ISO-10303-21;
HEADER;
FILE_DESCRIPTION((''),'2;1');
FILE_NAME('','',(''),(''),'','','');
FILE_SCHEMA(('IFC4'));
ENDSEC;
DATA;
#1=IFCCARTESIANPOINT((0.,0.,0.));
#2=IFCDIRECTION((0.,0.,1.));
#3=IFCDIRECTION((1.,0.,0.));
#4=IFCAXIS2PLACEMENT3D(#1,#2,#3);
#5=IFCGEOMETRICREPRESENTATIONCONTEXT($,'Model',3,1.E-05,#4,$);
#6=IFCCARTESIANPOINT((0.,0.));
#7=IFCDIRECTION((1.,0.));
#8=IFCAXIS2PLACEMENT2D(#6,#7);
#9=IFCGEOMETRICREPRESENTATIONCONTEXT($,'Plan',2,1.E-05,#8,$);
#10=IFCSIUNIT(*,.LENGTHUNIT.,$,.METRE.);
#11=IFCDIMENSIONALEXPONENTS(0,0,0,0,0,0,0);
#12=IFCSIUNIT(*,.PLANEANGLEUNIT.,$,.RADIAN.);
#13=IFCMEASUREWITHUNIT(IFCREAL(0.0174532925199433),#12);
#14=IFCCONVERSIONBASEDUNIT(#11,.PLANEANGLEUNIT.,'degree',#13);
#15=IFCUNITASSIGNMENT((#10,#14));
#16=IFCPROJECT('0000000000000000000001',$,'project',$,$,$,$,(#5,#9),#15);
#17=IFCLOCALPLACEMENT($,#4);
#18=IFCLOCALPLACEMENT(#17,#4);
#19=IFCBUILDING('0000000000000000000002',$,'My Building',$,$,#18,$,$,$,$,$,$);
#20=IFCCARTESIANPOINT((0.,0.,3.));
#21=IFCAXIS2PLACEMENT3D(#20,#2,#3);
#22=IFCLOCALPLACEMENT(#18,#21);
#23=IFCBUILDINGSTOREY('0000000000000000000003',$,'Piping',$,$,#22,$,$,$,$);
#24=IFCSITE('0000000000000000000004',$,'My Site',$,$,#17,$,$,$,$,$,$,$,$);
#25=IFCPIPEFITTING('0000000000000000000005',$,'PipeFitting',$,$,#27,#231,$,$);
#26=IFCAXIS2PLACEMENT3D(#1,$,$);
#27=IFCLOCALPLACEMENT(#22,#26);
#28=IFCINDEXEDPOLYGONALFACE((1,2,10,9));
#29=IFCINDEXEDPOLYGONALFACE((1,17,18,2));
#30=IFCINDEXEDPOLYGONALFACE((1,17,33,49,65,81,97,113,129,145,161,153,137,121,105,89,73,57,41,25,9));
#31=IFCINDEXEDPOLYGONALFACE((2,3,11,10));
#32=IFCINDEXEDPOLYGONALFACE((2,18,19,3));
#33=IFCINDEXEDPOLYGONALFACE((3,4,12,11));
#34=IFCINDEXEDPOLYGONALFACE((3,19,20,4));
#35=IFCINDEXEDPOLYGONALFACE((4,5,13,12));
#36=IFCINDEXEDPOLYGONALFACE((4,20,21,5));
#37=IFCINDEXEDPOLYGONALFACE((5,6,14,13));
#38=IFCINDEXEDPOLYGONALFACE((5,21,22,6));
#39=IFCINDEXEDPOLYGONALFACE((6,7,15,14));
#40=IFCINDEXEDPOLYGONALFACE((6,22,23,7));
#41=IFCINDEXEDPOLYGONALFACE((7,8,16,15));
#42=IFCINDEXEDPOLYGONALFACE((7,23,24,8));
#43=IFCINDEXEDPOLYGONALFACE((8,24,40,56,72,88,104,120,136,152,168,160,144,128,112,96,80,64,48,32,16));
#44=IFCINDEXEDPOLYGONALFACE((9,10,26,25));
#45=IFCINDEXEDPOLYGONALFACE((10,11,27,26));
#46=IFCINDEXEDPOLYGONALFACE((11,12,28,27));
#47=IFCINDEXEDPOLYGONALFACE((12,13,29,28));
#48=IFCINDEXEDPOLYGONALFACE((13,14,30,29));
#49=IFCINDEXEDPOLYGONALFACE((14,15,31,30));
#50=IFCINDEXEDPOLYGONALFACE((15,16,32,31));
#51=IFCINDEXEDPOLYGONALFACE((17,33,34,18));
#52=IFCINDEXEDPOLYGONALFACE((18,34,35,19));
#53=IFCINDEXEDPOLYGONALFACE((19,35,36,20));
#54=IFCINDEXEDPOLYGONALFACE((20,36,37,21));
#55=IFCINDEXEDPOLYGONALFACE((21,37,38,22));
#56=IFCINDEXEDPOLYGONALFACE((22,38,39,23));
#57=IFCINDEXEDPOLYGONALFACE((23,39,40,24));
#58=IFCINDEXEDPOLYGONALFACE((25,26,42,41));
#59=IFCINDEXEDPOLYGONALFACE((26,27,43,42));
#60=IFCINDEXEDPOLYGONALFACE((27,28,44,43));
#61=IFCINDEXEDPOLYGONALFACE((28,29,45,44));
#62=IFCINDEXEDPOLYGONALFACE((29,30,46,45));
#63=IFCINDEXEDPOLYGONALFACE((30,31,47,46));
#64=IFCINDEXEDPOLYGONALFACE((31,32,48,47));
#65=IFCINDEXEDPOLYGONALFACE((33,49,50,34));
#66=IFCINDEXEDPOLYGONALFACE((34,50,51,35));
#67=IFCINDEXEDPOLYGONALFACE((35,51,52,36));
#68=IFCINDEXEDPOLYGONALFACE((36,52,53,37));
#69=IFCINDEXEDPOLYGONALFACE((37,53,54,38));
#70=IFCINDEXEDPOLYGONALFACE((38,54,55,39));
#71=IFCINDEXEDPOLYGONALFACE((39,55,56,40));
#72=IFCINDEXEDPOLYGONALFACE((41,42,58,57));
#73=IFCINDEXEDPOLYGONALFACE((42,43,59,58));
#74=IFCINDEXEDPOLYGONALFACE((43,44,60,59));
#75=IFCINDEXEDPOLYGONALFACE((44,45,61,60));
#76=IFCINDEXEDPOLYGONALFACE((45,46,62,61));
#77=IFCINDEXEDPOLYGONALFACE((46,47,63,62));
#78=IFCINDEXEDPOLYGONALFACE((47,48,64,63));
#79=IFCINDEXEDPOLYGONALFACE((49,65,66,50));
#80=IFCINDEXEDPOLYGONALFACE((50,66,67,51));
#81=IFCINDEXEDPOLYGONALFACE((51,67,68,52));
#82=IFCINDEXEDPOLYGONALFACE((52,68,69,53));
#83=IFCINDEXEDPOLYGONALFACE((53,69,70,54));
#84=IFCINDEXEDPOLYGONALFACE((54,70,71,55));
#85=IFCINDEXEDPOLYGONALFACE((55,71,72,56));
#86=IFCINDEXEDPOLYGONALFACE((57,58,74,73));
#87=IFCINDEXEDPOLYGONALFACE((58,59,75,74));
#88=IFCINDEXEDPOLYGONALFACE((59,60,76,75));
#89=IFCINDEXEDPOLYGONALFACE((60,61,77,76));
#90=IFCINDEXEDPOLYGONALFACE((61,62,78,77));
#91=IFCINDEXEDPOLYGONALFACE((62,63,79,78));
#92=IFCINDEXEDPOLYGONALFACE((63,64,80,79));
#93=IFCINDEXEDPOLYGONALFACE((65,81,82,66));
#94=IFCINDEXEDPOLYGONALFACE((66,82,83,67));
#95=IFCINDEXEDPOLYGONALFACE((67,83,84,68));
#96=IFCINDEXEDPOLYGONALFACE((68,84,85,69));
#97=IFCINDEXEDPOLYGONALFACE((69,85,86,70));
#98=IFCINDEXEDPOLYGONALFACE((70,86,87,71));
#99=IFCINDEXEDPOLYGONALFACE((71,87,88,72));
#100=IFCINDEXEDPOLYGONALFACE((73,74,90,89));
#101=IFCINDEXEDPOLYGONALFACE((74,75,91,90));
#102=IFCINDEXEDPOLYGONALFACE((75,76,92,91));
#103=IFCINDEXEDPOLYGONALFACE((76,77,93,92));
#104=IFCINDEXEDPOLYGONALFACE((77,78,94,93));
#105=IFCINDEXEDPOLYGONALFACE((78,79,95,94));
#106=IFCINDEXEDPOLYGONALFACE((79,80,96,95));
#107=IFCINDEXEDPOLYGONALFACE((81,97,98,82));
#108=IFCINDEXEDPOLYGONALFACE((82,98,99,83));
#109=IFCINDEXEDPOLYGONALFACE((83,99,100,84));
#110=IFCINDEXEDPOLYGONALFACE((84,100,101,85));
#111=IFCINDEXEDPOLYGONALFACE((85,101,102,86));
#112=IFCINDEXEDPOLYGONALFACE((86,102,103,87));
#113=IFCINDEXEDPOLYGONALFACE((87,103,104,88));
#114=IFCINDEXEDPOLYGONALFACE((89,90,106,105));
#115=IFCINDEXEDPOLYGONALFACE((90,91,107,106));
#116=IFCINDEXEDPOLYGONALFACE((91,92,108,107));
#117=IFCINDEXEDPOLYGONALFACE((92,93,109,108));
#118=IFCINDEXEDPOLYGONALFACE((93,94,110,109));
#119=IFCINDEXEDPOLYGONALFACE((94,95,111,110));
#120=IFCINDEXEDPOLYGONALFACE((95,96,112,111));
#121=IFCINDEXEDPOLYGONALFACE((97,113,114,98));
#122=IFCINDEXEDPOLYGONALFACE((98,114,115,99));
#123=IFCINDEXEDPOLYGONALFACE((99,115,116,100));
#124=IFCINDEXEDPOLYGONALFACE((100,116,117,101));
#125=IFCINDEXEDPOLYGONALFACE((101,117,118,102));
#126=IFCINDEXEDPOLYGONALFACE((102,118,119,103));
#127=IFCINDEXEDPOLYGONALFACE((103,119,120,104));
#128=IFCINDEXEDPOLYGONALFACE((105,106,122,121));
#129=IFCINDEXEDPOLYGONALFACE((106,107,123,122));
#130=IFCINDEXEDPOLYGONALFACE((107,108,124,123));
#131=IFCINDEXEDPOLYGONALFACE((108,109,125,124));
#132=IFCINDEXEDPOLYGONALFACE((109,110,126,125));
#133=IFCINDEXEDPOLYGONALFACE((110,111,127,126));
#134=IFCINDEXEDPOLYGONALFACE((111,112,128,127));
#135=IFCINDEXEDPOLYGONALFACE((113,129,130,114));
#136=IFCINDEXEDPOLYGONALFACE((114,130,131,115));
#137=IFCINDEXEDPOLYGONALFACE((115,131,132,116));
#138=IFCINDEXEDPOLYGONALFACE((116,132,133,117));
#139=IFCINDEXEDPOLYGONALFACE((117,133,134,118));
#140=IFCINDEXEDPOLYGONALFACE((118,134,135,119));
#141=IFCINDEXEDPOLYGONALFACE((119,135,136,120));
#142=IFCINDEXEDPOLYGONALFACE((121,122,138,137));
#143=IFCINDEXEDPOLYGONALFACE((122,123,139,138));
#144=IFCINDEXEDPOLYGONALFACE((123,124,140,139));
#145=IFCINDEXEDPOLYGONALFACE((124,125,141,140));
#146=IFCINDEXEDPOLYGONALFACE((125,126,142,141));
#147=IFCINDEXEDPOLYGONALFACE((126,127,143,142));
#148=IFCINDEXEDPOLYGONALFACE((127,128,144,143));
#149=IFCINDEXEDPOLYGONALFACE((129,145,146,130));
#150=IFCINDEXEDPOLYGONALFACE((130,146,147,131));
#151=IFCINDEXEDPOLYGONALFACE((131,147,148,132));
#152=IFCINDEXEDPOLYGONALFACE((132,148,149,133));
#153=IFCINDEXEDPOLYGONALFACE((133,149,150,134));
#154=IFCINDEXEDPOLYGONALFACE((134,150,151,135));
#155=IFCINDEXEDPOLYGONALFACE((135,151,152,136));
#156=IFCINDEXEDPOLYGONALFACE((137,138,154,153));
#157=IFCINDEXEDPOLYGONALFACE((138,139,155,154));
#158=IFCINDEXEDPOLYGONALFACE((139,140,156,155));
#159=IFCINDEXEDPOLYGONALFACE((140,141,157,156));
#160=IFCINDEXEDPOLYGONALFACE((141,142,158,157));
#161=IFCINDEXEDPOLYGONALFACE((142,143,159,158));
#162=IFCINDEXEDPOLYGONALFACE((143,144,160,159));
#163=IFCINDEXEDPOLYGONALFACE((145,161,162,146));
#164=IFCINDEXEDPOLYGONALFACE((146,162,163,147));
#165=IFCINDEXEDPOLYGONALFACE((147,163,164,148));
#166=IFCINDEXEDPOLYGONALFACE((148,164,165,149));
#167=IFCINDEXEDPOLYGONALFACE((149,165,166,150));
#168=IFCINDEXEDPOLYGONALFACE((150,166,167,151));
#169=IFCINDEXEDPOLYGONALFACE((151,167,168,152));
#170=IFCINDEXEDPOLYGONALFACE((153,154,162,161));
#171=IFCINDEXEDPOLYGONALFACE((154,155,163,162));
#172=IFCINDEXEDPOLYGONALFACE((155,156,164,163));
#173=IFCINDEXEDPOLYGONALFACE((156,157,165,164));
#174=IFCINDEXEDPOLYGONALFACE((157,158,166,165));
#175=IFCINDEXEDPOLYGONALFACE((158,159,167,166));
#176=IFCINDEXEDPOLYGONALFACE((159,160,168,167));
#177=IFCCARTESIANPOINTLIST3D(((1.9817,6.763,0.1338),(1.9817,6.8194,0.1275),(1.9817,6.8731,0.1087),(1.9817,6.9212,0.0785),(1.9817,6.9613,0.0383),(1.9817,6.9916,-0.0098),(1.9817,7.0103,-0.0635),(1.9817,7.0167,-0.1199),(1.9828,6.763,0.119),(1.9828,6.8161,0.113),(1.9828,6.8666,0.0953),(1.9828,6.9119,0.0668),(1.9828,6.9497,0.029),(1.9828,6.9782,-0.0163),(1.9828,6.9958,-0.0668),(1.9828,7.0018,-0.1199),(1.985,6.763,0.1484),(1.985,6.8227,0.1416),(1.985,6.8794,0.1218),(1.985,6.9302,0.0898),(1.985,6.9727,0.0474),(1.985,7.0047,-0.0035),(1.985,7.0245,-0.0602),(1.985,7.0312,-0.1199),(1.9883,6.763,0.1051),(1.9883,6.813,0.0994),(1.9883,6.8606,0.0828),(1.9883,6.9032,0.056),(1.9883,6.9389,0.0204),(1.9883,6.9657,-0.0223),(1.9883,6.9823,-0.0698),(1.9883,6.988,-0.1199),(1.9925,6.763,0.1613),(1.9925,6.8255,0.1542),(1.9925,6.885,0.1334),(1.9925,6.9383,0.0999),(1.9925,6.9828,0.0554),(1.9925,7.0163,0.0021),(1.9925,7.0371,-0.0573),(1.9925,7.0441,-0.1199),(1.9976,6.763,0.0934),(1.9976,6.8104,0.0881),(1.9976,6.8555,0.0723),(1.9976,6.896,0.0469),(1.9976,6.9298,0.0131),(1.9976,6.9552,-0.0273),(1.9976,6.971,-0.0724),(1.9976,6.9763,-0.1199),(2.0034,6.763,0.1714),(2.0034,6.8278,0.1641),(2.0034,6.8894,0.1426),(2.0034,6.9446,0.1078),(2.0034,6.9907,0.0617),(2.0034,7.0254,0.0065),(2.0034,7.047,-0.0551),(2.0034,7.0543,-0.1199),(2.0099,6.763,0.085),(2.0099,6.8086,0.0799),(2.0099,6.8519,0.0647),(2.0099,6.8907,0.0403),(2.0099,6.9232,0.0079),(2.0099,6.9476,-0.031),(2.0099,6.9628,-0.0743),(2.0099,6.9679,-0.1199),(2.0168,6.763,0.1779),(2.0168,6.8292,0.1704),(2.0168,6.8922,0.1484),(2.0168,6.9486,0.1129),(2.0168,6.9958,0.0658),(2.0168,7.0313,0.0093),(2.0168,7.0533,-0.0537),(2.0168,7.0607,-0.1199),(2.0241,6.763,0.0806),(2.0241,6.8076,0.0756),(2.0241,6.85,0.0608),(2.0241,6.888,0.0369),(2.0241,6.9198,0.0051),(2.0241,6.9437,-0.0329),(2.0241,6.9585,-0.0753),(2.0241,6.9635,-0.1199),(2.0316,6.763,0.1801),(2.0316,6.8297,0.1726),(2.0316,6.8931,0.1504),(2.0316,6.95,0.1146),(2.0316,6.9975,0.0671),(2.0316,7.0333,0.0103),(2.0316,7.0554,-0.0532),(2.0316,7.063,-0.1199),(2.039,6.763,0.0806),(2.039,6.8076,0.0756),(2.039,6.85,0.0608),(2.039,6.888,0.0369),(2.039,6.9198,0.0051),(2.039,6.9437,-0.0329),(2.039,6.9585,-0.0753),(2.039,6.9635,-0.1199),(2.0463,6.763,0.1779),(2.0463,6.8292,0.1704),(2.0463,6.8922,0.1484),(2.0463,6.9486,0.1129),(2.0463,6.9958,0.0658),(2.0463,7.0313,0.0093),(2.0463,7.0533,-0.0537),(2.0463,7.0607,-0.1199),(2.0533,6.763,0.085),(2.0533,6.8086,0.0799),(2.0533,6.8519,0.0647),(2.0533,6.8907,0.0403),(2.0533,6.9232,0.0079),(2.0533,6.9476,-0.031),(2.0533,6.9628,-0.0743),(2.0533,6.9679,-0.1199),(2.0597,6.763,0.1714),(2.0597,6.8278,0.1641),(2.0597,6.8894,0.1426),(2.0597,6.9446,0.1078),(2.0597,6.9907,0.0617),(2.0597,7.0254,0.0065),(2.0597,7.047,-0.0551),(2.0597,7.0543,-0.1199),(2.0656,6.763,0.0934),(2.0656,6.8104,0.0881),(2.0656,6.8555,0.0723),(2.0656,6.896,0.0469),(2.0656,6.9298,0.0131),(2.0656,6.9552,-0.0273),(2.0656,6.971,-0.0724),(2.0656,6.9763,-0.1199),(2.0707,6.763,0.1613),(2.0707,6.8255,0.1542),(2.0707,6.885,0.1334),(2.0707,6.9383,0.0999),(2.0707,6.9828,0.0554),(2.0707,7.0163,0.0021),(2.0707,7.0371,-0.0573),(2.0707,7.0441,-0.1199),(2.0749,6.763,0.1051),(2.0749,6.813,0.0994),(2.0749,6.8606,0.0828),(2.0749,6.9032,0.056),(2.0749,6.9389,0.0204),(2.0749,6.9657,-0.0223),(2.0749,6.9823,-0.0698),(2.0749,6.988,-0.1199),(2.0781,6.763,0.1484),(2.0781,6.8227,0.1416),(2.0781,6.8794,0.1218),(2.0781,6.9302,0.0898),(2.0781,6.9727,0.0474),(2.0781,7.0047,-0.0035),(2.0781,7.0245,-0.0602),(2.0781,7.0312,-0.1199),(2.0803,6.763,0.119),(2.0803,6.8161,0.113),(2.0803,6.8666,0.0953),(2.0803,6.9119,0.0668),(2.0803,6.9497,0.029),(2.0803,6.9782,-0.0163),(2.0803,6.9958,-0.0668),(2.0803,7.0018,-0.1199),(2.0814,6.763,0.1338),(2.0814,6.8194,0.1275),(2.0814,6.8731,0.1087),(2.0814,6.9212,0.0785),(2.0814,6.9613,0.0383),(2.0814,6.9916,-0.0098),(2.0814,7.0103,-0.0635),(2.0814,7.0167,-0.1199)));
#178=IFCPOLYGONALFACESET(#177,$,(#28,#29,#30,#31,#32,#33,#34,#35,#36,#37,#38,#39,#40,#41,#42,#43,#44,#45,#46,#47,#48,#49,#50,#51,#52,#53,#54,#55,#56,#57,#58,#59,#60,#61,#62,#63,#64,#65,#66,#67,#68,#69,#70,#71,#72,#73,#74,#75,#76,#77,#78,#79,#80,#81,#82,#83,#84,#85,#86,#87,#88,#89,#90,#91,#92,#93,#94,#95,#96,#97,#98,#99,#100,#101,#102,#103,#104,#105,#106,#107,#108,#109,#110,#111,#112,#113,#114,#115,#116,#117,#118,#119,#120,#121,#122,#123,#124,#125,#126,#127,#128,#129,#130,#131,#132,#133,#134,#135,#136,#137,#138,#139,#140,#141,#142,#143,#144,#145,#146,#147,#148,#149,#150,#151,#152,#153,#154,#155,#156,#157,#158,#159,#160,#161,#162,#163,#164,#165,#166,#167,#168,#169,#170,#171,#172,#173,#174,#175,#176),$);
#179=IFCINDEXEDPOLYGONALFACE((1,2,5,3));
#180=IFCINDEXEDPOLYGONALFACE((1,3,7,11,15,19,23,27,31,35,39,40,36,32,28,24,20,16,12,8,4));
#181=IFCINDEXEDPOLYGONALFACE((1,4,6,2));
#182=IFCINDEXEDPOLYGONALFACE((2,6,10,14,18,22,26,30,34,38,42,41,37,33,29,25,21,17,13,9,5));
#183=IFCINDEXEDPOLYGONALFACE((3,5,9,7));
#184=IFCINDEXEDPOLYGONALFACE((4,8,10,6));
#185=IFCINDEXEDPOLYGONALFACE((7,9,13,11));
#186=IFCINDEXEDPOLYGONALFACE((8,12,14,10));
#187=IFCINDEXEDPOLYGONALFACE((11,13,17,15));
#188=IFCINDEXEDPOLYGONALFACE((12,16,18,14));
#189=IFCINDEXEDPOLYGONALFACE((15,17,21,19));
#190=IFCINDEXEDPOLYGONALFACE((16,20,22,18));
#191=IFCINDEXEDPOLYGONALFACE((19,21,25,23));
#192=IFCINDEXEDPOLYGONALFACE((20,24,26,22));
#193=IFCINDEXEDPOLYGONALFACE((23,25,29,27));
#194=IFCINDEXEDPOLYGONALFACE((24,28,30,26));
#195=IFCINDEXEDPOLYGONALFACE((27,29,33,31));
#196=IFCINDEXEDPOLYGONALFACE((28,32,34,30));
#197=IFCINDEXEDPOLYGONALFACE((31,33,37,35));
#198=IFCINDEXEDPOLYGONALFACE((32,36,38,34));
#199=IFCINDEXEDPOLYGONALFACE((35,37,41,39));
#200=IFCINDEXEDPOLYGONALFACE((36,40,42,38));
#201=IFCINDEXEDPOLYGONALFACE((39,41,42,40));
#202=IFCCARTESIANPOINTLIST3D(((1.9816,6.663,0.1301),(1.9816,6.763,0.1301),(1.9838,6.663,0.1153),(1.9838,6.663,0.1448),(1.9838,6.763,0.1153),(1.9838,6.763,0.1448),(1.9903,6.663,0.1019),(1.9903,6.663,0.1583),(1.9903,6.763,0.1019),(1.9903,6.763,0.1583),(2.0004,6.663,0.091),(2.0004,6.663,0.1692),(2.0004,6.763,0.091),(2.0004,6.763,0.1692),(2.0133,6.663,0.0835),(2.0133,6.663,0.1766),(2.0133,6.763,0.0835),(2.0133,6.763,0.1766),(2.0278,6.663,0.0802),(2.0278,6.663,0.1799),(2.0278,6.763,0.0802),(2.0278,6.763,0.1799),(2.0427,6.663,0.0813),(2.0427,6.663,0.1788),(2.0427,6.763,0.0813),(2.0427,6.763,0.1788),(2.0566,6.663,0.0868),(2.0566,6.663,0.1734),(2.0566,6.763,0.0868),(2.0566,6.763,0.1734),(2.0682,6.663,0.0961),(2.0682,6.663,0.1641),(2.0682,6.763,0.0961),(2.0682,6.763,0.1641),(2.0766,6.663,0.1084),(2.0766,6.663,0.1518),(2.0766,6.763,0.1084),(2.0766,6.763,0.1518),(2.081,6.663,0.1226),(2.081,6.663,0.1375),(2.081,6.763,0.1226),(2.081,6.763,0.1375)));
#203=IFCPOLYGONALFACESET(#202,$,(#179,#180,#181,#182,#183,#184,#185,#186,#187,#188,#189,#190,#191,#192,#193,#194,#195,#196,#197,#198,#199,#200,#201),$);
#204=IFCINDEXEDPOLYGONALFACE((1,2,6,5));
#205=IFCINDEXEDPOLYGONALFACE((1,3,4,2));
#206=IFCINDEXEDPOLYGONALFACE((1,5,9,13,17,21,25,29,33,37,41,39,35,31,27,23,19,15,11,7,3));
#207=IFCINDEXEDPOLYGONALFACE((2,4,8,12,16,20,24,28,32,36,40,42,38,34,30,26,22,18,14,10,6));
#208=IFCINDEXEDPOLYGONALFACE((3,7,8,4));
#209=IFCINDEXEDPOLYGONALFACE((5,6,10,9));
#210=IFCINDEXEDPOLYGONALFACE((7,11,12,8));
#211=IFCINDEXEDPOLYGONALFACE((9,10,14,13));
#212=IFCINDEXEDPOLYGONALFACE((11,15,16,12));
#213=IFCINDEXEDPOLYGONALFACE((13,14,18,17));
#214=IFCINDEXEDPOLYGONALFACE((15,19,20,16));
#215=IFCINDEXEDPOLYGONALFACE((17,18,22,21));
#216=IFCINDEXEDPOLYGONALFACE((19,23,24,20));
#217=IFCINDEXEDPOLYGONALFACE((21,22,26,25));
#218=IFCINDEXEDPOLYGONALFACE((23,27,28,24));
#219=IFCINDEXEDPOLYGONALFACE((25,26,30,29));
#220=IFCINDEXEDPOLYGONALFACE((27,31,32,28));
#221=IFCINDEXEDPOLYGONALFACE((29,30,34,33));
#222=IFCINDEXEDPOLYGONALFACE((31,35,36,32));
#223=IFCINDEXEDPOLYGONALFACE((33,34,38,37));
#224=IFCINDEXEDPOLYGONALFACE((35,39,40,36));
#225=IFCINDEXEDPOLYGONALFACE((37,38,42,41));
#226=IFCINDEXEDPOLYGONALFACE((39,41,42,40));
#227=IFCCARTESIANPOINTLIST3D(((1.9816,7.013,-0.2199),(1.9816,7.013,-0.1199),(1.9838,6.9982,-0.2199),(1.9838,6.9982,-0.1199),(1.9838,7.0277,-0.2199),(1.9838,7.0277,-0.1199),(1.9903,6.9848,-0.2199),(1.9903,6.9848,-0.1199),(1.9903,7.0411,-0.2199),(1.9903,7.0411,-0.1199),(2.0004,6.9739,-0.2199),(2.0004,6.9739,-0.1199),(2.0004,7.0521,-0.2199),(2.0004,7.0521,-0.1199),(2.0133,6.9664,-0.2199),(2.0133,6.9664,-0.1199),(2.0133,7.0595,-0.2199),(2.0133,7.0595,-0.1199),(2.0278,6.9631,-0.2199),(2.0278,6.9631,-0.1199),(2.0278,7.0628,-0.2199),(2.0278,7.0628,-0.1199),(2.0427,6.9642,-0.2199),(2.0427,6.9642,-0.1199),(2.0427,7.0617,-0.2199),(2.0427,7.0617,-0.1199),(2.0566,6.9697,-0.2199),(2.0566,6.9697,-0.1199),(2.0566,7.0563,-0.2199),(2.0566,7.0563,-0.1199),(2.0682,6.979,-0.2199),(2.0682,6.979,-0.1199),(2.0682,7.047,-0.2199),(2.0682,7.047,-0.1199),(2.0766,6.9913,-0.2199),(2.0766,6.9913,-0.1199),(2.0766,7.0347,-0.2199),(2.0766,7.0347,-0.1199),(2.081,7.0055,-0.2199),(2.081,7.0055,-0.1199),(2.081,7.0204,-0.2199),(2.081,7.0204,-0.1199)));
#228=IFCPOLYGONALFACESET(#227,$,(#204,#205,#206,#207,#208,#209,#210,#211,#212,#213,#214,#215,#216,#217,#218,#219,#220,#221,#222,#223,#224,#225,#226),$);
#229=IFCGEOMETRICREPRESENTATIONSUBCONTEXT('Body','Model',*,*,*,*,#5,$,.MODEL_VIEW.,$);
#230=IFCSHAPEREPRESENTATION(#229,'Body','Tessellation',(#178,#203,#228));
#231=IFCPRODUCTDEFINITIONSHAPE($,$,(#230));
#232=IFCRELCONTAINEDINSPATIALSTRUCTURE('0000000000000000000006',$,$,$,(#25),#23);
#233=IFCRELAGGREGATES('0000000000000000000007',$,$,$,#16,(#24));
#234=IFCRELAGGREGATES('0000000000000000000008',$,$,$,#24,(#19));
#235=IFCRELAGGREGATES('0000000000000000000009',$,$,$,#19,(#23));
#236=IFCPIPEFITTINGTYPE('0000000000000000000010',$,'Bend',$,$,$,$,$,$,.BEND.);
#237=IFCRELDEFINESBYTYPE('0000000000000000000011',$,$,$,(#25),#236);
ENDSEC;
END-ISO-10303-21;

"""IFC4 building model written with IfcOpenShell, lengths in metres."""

from ifc_helpers import new_model, entity, si_unit, converted_unit, frame, origin_with_axes, origin_2d_with_axis, place, context, subcontext, project, spatial, circle, extrude, source, transform, mapped, type_object, type_shapes, element, save


model = new_model("IFC4")

# Units and contexts
model_context = context("Model", 3, precision=1e-05, world=origin_with_axes())
plan_context = context("Plan", 2, precision=1e-05, world=origin_2d_with_axis())
body_context = subcontext(model_context, "Body", "Model", "MODEL_VIEW")
ifc_project = project(units=[si_unit("LENGTHUNIT", "METRE"), converted_unit("PLANEANGLEUNIT", "degree", entity("IfcReal", 0.0174532925199433), si_unit("PLANEANGLEUNIT", "RADIAN"), dimensions=[0, 0, 0, 0, 0, 0, 0])], contexts=[model_context, plan_context])

# Site, building, storey
site_placement = place(None, origin_with_axes())
site = spatial("IfcSite", under=ifc_project, at=site_placement, Name="My Site")
building_placement = place(site_placement, origin_with_axes())
building = spatial("IfcBuilding", under=site, at=building_placement, Name="My Building")
storey_placement = place(building_placement, frame((0.0, 0.0, 3.0), z_axis=(0.0, 0.0, 1.0), x_axis=(1.0, 0.0, 0.0)))
storey = spatial("IfcBuildingStorey", under=building, at=storey_placement, Name="Piping")

# Pipe fitting
pipe_fitting_type_1 = type_object("IfcPipeFittingType", Name="Bend", PredefinedType="BEND")
shared_shape_1 = source(origin_with_axes(), body_context, "Body", "SolidModel", [
    entity("IfcSweptDiskSolid", entity("IfcIndexedPolyCurve", entity("IfcCartesianPointList3D", [[0.0, 0.0, 0.1], [0.0, -0.0732, 0.2768], [0.0, -0.25, 0.35]]), [entity("IfcArcIndex", [1, 2, 3])]), 0.05),
    extrude(circle(Radius=0.05), origin_with_axes(), (0.0, 0.0, 1.0), 0.1),
    extrude(circle(Radius=0.05), frame((0.0, -0.25, 0.35), z_axis=(0.0, -1.0, -0.000015), x_axis=(1.0, 0.0, 0.0)), (0.0, 0.0, 1.0), 0.1),
])
type_shapes(pipe_fitting_type_1, [shared_shape_1])
for number, where, z_axis, x_axis, name in (
    (1, (2.0316, 6.663, 0.1301), (0.0, 1.0, 0.000015), (-1.0, 0.0, 0.0), "PipeFitting"),
):
    element("IfcPipeFitting", number, at=place(storey_placement, frame(where, z_axis=z_axis, x_axis=x_axis)), inside=storey, type_object=pipe_fitting_type_1, Name=name, context=body_context, shape_type="MappedRepresentation", body=[
        mapped(shared_shape_1, transform((0.0, 0.0, 0.0), x_axis=(1.0, 0.0, 0.0), y_axis=(0.0, 1.0, 0.0), z_axis=(0.0, 0.0, 1.0), scale=1.0)),
    ])

save(model, "model.ifc")
